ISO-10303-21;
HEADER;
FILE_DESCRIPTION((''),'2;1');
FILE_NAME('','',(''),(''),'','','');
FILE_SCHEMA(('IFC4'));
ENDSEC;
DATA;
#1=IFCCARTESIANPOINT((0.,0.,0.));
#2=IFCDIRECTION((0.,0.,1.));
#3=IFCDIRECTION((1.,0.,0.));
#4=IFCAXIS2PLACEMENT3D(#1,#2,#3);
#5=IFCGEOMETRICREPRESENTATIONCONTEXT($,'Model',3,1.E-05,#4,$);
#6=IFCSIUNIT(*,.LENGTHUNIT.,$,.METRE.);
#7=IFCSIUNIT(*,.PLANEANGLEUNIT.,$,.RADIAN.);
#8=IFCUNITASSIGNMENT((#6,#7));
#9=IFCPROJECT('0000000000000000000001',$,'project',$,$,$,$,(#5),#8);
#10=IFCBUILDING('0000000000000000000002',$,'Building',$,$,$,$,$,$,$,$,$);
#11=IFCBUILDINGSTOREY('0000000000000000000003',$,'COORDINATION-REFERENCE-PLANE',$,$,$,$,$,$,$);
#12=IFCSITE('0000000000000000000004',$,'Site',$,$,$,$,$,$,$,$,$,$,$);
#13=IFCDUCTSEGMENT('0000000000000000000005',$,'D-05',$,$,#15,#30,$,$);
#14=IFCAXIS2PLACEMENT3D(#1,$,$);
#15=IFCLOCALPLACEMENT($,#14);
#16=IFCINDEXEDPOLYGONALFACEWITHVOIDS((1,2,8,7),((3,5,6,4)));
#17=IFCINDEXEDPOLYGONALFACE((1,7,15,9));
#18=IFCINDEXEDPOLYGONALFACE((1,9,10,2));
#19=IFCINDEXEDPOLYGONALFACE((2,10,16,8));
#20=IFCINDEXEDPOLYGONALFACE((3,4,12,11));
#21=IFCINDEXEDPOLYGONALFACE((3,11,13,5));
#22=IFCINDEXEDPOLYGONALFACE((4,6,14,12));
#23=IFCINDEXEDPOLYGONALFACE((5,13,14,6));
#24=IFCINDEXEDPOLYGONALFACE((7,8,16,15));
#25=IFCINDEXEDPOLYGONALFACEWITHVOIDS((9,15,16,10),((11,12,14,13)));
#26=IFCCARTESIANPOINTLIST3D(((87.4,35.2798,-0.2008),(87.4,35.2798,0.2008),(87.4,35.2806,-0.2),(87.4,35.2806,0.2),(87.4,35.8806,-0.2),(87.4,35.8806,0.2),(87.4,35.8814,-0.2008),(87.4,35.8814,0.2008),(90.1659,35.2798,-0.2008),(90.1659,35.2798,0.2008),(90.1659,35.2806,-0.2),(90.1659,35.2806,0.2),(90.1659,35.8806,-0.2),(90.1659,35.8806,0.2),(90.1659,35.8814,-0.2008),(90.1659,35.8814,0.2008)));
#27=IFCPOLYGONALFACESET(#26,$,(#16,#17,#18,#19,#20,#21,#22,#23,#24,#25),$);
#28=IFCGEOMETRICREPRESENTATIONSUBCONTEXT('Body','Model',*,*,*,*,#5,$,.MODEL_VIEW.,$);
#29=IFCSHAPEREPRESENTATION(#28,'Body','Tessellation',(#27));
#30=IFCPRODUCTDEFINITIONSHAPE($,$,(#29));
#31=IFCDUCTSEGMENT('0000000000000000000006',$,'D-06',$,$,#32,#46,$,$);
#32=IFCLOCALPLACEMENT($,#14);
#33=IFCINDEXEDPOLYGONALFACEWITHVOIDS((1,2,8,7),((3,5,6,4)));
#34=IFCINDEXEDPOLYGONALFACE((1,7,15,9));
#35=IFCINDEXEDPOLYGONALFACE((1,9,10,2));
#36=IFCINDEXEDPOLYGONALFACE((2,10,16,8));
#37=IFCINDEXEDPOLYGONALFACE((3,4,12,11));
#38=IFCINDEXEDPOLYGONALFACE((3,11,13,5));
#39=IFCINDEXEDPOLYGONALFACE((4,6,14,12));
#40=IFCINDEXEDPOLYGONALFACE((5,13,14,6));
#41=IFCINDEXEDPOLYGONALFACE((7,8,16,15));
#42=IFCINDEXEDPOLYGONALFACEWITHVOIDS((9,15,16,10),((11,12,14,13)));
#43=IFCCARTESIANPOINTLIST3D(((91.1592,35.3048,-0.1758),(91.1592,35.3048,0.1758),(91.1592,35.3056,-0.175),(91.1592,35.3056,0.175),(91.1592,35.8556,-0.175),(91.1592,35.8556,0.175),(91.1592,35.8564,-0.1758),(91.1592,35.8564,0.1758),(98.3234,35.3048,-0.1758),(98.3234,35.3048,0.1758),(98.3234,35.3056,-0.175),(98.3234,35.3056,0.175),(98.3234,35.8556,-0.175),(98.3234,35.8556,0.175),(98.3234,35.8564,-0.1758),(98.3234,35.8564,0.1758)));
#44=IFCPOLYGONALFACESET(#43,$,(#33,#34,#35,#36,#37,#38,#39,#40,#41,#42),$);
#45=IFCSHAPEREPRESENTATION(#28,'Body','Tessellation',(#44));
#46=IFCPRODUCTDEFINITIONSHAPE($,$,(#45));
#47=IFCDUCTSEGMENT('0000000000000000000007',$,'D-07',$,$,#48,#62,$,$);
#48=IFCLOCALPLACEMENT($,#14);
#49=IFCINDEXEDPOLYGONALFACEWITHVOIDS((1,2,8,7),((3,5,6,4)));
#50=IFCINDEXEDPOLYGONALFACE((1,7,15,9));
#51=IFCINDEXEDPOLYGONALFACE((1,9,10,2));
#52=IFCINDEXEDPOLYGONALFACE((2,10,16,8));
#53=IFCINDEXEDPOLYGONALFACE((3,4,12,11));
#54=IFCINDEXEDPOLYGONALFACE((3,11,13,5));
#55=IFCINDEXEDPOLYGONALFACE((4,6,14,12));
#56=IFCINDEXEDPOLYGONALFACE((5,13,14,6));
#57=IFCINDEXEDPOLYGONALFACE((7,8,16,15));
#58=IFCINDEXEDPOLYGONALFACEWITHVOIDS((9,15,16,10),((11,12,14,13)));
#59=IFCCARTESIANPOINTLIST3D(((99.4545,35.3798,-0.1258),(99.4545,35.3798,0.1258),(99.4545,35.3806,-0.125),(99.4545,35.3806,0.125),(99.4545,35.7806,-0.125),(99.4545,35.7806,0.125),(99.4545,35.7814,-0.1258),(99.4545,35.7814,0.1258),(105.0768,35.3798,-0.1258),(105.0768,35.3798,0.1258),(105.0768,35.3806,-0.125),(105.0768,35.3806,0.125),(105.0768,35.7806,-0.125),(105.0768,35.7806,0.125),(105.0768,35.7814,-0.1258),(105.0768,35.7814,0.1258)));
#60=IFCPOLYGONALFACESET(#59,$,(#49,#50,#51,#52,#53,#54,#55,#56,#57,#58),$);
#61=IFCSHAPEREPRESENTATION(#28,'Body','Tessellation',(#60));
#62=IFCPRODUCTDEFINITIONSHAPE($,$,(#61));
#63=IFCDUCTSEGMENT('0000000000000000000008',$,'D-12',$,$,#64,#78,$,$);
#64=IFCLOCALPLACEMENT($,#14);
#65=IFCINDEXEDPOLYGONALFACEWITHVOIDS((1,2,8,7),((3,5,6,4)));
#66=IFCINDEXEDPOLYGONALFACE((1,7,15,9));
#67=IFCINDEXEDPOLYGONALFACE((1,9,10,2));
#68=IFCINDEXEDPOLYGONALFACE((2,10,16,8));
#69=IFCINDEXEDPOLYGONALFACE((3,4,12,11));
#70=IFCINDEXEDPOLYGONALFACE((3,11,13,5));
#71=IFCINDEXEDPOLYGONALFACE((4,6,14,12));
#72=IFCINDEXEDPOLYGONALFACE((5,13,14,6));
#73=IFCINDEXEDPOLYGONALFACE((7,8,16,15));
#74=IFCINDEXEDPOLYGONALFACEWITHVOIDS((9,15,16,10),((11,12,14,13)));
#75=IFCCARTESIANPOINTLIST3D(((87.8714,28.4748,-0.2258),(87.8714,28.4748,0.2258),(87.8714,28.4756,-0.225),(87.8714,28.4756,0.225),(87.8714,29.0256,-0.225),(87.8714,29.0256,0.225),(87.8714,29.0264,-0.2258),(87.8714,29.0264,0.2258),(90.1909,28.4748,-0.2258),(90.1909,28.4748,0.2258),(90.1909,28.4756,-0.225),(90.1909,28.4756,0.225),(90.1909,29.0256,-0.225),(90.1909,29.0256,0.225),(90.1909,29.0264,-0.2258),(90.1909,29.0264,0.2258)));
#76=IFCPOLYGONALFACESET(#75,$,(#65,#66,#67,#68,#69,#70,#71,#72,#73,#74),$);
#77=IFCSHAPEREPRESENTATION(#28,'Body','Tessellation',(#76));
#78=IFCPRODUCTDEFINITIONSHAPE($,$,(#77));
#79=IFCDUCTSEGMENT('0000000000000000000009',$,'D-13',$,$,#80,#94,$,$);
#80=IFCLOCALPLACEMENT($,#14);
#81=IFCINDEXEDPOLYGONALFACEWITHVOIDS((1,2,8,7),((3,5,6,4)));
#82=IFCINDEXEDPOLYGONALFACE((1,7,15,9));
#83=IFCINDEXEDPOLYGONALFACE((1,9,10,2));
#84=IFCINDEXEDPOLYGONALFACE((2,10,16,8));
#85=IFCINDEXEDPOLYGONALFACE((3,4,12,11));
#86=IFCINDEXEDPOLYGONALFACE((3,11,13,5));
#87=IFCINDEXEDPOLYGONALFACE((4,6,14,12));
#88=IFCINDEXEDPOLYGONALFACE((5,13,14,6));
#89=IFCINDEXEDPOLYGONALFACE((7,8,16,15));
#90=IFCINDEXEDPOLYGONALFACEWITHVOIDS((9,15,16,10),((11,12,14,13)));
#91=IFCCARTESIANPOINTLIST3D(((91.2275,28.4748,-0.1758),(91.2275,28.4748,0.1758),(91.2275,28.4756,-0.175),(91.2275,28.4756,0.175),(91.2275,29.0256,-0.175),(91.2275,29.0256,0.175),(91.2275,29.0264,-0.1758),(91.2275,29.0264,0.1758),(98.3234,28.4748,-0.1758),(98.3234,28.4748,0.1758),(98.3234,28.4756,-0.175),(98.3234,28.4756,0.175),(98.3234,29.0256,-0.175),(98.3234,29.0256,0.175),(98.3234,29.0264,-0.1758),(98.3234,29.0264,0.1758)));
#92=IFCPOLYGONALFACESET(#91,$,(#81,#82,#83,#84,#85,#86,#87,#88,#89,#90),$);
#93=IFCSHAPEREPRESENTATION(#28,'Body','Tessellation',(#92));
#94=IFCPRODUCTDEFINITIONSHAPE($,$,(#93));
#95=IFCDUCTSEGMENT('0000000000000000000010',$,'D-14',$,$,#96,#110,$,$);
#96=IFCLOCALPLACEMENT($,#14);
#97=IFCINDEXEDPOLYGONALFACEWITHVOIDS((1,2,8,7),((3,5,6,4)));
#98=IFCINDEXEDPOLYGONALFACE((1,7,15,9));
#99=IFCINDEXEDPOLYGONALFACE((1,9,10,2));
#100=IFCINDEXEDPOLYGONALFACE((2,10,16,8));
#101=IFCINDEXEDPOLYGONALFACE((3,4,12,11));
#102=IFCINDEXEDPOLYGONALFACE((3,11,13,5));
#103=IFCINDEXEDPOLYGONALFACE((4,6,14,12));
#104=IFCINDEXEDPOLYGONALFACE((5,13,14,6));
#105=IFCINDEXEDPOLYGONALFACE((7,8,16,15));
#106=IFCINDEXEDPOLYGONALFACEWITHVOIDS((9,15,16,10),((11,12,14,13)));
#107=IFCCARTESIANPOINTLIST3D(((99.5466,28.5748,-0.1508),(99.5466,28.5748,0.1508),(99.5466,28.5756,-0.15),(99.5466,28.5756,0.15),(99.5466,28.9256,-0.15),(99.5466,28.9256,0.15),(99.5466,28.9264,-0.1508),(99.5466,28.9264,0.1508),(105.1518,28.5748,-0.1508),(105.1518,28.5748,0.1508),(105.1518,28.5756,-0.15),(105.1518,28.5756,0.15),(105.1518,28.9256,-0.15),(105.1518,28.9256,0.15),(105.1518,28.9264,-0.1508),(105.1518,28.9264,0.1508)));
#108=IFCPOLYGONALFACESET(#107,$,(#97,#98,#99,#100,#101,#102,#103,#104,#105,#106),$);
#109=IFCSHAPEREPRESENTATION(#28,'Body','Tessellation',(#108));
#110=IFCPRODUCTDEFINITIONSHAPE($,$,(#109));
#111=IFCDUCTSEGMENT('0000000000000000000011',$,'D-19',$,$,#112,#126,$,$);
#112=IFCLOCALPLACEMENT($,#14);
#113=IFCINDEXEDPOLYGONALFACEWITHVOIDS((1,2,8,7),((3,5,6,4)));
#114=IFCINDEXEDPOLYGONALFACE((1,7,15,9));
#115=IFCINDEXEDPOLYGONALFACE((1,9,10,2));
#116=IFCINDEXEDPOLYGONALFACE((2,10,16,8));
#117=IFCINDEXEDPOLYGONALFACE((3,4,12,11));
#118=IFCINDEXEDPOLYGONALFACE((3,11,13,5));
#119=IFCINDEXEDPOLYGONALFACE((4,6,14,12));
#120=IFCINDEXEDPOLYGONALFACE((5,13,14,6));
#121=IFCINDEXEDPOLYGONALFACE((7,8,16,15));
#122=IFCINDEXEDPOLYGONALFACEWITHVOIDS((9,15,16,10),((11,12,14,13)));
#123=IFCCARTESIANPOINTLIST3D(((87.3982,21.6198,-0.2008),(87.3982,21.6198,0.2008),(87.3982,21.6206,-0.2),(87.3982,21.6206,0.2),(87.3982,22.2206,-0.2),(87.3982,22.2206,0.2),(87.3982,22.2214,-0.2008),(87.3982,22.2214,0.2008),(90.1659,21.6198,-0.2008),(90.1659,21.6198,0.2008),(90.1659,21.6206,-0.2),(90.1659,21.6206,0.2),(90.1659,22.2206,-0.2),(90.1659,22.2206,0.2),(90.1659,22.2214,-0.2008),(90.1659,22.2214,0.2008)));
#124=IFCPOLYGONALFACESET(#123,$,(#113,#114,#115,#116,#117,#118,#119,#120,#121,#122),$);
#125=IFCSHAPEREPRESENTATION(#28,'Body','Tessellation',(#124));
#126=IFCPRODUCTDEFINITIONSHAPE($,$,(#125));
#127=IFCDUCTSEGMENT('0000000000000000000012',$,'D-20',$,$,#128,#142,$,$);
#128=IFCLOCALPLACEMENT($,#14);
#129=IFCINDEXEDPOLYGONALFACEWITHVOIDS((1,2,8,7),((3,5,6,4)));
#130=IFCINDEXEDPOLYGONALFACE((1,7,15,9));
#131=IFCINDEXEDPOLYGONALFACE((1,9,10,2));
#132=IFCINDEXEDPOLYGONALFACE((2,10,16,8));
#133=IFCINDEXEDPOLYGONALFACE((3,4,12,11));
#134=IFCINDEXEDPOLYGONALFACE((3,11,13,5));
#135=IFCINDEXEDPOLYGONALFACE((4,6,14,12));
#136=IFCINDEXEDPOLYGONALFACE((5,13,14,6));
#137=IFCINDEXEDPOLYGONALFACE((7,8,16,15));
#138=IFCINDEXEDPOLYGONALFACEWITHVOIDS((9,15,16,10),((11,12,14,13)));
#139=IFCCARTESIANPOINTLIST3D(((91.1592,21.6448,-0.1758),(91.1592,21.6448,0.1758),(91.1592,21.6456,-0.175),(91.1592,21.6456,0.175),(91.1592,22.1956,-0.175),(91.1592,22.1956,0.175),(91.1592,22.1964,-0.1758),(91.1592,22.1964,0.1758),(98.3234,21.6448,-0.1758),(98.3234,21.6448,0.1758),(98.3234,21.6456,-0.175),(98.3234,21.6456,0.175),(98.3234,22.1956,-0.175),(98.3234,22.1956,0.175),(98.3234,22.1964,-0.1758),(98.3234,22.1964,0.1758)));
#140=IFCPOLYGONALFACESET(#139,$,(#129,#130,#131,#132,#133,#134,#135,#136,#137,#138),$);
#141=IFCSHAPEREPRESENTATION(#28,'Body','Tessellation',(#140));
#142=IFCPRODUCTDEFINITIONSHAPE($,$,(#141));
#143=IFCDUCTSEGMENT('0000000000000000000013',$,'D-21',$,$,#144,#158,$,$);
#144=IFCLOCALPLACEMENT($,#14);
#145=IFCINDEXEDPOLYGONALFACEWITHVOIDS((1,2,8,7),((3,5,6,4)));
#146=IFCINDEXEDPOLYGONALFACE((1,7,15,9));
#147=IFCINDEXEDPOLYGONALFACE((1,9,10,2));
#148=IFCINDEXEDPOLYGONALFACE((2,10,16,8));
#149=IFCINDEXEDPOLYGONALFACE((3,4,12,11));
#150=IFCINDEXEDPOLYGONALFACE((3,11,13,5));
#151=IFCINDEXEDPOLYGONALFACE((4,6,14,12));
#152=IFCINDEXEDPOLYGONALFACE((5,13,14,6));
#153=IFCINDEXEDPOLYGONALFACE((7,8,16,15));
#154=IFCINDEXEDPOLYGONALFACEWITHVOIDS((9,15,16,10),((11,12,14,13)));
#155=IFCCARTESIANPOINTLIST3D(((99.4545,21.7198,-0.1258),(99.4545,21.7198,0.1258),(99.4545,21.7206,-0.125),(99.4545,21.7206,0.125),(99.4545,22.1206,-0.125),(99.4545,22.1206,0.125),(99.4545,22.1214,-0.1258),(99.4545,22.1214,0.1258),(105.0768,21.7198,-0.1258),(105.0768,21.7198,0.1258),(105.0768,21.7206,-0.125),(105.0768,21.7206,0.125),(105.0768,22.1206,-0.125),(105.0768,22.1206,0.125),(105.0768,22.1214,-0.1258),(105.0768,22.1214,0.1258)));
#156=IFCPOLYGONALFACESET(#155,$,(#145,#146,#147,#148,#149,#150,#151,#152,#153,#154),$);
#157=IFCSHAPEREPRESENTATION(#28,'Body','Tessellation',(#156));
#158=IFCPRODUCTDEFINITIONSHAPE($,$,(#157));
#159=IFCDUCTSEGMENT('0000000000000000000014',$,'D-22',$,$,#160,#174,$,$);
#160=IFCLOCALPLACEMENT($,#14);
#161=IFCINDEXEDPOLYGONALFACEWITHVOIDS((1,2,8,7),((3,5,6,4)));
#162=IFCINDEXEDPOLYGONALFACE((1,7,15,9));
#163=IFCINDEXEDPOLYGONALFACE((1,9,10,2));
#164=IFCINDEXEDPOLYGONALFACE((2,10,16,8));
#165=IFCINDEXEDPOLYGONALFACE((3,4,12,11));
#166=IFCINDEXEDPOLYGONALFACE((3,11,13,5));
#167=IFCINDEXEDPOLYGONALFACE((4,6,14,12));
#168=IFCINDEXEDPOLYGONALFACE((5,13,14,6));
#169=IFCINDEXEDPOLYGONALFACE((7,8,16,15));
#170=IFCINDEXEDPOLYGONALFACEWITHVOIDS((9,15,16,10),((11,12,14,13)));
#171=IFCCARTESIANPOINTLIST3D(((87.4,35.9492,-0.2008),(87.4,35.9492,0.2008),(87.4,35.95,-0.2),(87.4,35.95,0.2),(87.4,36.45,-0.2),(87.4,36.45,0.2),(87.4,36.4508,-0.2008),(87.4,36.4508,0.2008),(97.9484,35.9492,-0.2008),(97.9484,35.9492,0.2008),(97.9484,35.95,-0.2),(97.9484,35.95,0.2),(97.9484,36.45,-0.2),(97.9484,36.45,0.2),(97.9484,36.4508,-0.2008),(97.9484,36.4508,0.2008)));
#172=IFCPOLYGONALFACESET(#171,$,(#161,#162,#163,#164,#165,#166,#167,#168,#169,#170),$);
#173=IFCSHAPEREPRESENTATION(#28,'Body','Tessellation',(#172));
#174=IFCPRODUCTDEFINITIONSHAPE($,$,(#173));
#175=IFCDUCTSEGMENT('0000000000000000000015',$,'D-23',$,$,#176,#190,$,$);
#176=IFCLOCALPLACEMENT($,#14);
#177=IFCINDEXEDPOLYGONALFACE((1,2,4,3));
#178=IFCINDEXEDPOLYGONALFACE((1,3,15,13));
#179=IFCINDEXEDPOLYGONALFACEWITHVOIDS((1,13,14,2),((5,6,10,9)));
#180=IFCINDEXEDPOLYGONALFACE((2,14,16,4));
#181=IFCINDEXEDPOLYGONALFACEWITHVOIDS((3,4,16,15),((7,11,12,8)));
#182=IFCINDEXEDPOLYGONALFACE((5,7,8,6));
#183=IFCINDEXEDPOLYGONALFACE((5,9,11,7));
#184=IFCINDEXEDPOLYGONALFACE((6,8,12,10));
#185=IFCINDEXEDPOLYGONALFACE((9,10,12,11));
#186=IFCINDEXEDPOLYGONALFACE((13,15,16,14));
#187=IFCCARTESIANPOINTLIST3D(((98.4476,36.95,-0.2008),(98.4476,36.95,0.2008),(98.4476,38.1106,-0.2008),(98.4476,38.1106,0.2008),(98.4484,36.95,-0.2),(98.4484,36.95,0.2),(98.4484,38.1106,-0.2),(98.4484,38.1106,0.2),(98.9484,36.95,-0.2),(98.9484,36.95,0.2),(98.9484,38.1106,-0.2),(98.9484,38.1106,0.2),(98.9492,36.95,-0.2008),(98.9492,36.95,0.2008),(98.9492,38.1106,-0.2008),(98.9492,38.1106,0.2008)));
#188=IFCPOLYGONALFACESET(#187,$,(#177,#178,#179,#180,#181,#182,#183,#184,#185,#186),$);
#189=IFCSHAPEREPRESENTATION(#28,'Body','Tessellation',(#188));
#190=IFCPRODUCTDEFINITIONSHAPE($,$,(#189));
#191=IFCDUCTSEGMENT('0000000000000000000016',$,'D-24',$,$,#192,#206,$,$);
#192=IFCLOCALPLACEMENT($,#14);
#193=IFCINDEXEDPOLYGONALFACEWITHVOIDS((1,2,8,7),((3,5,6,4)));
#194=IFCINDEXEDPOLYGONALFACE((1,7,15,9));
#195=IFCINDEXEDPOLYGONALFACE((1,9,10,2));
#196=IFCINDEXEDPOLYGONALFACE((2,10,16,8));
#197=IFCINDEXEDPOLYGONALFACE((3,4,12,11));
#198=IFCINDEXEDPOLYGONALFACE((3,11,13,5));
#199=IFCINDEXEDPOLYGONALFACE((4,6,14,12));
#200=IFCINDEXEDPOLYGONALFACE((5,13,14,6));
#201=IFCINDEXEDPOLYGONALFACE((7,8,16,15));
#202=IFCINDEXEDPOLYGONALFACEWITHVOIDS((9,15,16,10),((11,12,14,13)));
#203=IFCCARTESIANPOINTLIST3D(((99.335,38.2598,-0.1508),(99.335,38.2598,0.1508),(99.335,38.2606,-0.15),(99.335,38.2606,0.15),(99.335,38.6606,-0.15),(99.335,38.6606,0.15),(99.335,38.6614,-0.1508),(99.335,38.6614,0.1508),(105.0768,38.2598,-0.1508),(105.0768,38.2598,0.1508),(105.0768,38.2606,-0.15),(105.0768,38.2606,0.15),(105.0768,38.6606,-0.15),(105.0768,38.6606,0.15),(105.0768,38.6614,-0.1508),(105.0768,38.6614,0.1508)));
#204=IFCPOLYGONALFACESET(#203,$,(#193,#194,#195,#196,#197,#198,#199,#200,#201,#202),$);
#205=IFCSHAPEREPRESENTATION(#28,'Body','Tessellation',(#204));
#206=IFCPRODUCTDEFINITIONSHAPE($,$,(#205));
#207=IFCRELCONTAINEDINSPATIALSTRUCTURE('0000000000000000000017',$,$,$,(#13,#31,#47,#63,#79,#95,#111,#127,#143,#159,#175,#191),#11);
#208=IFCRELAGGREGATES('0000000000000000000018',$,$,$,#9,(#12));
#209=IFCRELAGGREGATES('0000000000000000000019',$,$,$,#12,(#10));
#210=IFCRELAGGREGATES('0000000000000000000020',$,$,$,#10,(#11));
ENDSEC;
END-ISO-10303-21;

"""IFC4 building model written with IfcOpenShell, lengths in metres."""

from ifc_helpers import new_model, si_unit, frame, origin, origin_with_axes, place, context, subcontext, project, spatial, hollow_rectangle, extrude, element, save


model = new_model("IFC4")

# Units and contexts
model_context = context("Model", 3, precision=1e-05, world=origin_with_axes())
body_context = subcontext(model_context, "Body", "Model", "MODEL_VIEW")
ifc_project = project(units=[si_unit("LENGTHUNIT", "METRE"), si_unit("PLANEANGLEUNIT", "RADIAN")], contexts=[model_context])

# Site, building, storey
site = spatial("IfcSite", under=ifc_project, Name="Site")
building = spatial("IfcBuilding", under=site, Name="Building")
storey = spatial("IfcBuildingStorey", under=building, Name="COORDINATION-REFERENCE-PLANE")

# Duct segments
duct_segment_1_placement = place(None, frame((87.4, 35.5806, 0.0), z_axis=(1.0, 0.0, 0.0), x_axis=(0.0, 1.0, 0.0)))
element("IfcDuctSegment", 1, at=duct_segment_1_placement, inside=storey, Name="D-05", context=body_context, shape_type="SweptSolid", body=[
    extrude(hollow_rectangle(XDim=0.6016, YDim=0.4016, WallThickness=0.0008), origin(), (0.0, 0.0, 1.0), 2.7659),
])
duct_segment_2_placement = place(None, frame((91.1592, 35.5806, 0.0), z_axis=(1.0, 0.0, 0.0), x_axis=(0.0, 1.0, 0.0)))
element("IfcDuctSegment", 2, at=duct_segment_2_placement, inside=storey, Name="D-06", context=body_context, shape_type="SweptSolid", body=[
    extrude(hollow_rectangle(XDim=0.5516, YDim=0.3516, WallThickness=0.0008), origin(), (0.0, 0.0, 1.0), 7.1642),
])
duct_segment_3_placement = place(None, frame((99.4545, 35.5806, 0.0), z_axis=(1.0, 0.0, 0.0), x_axis=(0.0, 1.0, 0.0)))
element("IfcDuctSegment", 3, at=duct_segment_3_placement, inside=storey, Name="D-07", context=body_context, shape_type="SweptSolid", body=[
    extrude(hollow_rectangle(XDim=0.4016, YDim=0.2516, WallThickness=0.0008), origin(), (0.0, 0.0, 1.0), 5.6223),
])
duct_segment_4_placement = place(None, frame((87.8714, 28.7506, 0.0), z_axis=(1.0, 0.0, 0.0), x_axis=(0.0, 1.0, 0.0)))
element("IfcDuctSegment", 4, at=duct_segment_4_placement, inside=storey, Name="D-12", context=body_context, shape_type="SweptSolid", body=[
    extrude(hollow_rectangle(XDim=0.5516, YDim=0.4516, WallThickness=0.0008), origin(), (0.0, 0.0, 1.0), 2.3195),
])
duct_segment_5_placement = place(None, frame((91.2275, 28.7506, 0.0), z_axis=(1.0, 0.0, 0.0), x_axis=(0.0, 1.0, 0.0)))
element("IfcDuctSegment", 5, at=duct_segment_5_placement, inside=storey, Name="D-13", context=body_context, shape_type="SweptSolid", body=[
    extrude(hollow_rectangle(XDim=0.5516, YDim=0.3516, WallThickness=0.0008), origin(), (0.0, 0.0, 1.0), 7.0959),
])
duct_segment_6_placement = place(None, frame((99.5466, 28.7506, 0.0), z_axis=(1.0, 0.0, 0.0), x_axis=(0.0, 1.0, 0.0)))
element("IfcDuctSegment", 6, at=duct_segment_6_placement, inside=storey, Name="D-14", context=body_context, shape_type="SweptSolid", body=[
    extrude(hollow_rectangle(XDim=0.3516, YDim=0.3016, WallThickness=0.0008), origin(), (0.0, 0.0, 1.0), 5.6051),
])
duct_segment_7_placement = place(None, frame((87.3982, 21.9206, 0.0), z_axis=(1.0, 0.0, 0.0), x_axis=(0.0, 1.0, 0.0)))
element("IfcDuctSegment", 7, at=duct_segment_7_placement, inside=storey, Name="D-19", context=body_context, shape_type="SweptSolid", body=[
    extrude(hollow_rectangle(XDim=0.6016, YDim=0.4016, WallThickness=0.0008), origin(), (0.0, 0.0, 1.0), 2.7677),
])
duct_segment_8_placement = place(None, frame((91.1592, 21.9206, 0.0), z_axis=(1.0, 0.0, 0.0), x_axis=(0.0, 1.0, 0.0)))
element("IfcDuctSegment", 8, at=duct_segment_8_placement, inside=storey, Name="D-20", context=body_context, shape_type="SweptSolid", body=[
    extrude(hollow_rectangle(XDim=0.5516, YDim=0.3516, WallThickness=0.0008), origin(), (0.0, 0.0, 1.0), 7.1642),
])
duct_segment_9_placement = place(None, frame((99.4545, 21.9206, 0.0), z_axis=(1.0, 0.0, 0.0), x_axis=(0.0, 1.0, 0.0)))
element("IfcDuctSegment", 9, at=duct_segment_9_placement, inside=storey, Name="D-21", context=body_context, shape_type="SweptSolid", body=[
    extrude(hollow_rectangle(XDim=0.4016, YDim=0.2516, WallThickness=0.0008), origin(), (0.0, 0.0, 1.0), 5.6223),
])
duct_segment_10_placement = place(None, frame((87.4, 36.2, 0.0), z_axis=(1.0, 0.0, 0.0), x_axis=(0.0, 1.0, 0.0)))
element("IfcDuctSegment", 10, at=duct_segment_10_placement, inside=storey, Name="D-22", context=body_context, shape_type="SweptSolid", body=[
    extrude(hollow_rectangle(XDim=0.5016, YDim=0.4016, WallThickness=0.0008), origin(), (0.0, 0.0, 1.0), 10.5484),
])
duct_segment_11_placement = place(None, frame((98.6984, 36.95, 0.0), z_axis=(0.0, 1.0, 0.0), x_axis=(1.0, 0.0, 0.0)))
element("IfcDuctSegment", 11, at=duct_segment_11_placement, inside=storey, Name="D-23", context=body_context, shape_type="SweptSolid", body=[
    extrude(hollow_rectangle(XDim=0.5016, YDim=0.4016, WallThickness=0.0008), origin(), (0.0, 0.0, 1.0), 1.1606),
])
duct_segment_12_placement = place(None, frame((99.335, 38.4606, 0.0), z_axis=(1.0, 0.0, 0.0), x_axis=(0.0, 1.0, 0.0)))
element("IfcDuctSegment", 12, at=duct_segment_12_placement, inside=storey, Name="D-24", context=body_context, shape_type="SweptSolid", body=[
    extrude(hollow_rectangle(XDim=0.4016, YDim=0.3016, WallThickness=0.0008), origin(), (0.0, 0.0, 1.0), 5.7417),
])

save(model, "model.ifc")
